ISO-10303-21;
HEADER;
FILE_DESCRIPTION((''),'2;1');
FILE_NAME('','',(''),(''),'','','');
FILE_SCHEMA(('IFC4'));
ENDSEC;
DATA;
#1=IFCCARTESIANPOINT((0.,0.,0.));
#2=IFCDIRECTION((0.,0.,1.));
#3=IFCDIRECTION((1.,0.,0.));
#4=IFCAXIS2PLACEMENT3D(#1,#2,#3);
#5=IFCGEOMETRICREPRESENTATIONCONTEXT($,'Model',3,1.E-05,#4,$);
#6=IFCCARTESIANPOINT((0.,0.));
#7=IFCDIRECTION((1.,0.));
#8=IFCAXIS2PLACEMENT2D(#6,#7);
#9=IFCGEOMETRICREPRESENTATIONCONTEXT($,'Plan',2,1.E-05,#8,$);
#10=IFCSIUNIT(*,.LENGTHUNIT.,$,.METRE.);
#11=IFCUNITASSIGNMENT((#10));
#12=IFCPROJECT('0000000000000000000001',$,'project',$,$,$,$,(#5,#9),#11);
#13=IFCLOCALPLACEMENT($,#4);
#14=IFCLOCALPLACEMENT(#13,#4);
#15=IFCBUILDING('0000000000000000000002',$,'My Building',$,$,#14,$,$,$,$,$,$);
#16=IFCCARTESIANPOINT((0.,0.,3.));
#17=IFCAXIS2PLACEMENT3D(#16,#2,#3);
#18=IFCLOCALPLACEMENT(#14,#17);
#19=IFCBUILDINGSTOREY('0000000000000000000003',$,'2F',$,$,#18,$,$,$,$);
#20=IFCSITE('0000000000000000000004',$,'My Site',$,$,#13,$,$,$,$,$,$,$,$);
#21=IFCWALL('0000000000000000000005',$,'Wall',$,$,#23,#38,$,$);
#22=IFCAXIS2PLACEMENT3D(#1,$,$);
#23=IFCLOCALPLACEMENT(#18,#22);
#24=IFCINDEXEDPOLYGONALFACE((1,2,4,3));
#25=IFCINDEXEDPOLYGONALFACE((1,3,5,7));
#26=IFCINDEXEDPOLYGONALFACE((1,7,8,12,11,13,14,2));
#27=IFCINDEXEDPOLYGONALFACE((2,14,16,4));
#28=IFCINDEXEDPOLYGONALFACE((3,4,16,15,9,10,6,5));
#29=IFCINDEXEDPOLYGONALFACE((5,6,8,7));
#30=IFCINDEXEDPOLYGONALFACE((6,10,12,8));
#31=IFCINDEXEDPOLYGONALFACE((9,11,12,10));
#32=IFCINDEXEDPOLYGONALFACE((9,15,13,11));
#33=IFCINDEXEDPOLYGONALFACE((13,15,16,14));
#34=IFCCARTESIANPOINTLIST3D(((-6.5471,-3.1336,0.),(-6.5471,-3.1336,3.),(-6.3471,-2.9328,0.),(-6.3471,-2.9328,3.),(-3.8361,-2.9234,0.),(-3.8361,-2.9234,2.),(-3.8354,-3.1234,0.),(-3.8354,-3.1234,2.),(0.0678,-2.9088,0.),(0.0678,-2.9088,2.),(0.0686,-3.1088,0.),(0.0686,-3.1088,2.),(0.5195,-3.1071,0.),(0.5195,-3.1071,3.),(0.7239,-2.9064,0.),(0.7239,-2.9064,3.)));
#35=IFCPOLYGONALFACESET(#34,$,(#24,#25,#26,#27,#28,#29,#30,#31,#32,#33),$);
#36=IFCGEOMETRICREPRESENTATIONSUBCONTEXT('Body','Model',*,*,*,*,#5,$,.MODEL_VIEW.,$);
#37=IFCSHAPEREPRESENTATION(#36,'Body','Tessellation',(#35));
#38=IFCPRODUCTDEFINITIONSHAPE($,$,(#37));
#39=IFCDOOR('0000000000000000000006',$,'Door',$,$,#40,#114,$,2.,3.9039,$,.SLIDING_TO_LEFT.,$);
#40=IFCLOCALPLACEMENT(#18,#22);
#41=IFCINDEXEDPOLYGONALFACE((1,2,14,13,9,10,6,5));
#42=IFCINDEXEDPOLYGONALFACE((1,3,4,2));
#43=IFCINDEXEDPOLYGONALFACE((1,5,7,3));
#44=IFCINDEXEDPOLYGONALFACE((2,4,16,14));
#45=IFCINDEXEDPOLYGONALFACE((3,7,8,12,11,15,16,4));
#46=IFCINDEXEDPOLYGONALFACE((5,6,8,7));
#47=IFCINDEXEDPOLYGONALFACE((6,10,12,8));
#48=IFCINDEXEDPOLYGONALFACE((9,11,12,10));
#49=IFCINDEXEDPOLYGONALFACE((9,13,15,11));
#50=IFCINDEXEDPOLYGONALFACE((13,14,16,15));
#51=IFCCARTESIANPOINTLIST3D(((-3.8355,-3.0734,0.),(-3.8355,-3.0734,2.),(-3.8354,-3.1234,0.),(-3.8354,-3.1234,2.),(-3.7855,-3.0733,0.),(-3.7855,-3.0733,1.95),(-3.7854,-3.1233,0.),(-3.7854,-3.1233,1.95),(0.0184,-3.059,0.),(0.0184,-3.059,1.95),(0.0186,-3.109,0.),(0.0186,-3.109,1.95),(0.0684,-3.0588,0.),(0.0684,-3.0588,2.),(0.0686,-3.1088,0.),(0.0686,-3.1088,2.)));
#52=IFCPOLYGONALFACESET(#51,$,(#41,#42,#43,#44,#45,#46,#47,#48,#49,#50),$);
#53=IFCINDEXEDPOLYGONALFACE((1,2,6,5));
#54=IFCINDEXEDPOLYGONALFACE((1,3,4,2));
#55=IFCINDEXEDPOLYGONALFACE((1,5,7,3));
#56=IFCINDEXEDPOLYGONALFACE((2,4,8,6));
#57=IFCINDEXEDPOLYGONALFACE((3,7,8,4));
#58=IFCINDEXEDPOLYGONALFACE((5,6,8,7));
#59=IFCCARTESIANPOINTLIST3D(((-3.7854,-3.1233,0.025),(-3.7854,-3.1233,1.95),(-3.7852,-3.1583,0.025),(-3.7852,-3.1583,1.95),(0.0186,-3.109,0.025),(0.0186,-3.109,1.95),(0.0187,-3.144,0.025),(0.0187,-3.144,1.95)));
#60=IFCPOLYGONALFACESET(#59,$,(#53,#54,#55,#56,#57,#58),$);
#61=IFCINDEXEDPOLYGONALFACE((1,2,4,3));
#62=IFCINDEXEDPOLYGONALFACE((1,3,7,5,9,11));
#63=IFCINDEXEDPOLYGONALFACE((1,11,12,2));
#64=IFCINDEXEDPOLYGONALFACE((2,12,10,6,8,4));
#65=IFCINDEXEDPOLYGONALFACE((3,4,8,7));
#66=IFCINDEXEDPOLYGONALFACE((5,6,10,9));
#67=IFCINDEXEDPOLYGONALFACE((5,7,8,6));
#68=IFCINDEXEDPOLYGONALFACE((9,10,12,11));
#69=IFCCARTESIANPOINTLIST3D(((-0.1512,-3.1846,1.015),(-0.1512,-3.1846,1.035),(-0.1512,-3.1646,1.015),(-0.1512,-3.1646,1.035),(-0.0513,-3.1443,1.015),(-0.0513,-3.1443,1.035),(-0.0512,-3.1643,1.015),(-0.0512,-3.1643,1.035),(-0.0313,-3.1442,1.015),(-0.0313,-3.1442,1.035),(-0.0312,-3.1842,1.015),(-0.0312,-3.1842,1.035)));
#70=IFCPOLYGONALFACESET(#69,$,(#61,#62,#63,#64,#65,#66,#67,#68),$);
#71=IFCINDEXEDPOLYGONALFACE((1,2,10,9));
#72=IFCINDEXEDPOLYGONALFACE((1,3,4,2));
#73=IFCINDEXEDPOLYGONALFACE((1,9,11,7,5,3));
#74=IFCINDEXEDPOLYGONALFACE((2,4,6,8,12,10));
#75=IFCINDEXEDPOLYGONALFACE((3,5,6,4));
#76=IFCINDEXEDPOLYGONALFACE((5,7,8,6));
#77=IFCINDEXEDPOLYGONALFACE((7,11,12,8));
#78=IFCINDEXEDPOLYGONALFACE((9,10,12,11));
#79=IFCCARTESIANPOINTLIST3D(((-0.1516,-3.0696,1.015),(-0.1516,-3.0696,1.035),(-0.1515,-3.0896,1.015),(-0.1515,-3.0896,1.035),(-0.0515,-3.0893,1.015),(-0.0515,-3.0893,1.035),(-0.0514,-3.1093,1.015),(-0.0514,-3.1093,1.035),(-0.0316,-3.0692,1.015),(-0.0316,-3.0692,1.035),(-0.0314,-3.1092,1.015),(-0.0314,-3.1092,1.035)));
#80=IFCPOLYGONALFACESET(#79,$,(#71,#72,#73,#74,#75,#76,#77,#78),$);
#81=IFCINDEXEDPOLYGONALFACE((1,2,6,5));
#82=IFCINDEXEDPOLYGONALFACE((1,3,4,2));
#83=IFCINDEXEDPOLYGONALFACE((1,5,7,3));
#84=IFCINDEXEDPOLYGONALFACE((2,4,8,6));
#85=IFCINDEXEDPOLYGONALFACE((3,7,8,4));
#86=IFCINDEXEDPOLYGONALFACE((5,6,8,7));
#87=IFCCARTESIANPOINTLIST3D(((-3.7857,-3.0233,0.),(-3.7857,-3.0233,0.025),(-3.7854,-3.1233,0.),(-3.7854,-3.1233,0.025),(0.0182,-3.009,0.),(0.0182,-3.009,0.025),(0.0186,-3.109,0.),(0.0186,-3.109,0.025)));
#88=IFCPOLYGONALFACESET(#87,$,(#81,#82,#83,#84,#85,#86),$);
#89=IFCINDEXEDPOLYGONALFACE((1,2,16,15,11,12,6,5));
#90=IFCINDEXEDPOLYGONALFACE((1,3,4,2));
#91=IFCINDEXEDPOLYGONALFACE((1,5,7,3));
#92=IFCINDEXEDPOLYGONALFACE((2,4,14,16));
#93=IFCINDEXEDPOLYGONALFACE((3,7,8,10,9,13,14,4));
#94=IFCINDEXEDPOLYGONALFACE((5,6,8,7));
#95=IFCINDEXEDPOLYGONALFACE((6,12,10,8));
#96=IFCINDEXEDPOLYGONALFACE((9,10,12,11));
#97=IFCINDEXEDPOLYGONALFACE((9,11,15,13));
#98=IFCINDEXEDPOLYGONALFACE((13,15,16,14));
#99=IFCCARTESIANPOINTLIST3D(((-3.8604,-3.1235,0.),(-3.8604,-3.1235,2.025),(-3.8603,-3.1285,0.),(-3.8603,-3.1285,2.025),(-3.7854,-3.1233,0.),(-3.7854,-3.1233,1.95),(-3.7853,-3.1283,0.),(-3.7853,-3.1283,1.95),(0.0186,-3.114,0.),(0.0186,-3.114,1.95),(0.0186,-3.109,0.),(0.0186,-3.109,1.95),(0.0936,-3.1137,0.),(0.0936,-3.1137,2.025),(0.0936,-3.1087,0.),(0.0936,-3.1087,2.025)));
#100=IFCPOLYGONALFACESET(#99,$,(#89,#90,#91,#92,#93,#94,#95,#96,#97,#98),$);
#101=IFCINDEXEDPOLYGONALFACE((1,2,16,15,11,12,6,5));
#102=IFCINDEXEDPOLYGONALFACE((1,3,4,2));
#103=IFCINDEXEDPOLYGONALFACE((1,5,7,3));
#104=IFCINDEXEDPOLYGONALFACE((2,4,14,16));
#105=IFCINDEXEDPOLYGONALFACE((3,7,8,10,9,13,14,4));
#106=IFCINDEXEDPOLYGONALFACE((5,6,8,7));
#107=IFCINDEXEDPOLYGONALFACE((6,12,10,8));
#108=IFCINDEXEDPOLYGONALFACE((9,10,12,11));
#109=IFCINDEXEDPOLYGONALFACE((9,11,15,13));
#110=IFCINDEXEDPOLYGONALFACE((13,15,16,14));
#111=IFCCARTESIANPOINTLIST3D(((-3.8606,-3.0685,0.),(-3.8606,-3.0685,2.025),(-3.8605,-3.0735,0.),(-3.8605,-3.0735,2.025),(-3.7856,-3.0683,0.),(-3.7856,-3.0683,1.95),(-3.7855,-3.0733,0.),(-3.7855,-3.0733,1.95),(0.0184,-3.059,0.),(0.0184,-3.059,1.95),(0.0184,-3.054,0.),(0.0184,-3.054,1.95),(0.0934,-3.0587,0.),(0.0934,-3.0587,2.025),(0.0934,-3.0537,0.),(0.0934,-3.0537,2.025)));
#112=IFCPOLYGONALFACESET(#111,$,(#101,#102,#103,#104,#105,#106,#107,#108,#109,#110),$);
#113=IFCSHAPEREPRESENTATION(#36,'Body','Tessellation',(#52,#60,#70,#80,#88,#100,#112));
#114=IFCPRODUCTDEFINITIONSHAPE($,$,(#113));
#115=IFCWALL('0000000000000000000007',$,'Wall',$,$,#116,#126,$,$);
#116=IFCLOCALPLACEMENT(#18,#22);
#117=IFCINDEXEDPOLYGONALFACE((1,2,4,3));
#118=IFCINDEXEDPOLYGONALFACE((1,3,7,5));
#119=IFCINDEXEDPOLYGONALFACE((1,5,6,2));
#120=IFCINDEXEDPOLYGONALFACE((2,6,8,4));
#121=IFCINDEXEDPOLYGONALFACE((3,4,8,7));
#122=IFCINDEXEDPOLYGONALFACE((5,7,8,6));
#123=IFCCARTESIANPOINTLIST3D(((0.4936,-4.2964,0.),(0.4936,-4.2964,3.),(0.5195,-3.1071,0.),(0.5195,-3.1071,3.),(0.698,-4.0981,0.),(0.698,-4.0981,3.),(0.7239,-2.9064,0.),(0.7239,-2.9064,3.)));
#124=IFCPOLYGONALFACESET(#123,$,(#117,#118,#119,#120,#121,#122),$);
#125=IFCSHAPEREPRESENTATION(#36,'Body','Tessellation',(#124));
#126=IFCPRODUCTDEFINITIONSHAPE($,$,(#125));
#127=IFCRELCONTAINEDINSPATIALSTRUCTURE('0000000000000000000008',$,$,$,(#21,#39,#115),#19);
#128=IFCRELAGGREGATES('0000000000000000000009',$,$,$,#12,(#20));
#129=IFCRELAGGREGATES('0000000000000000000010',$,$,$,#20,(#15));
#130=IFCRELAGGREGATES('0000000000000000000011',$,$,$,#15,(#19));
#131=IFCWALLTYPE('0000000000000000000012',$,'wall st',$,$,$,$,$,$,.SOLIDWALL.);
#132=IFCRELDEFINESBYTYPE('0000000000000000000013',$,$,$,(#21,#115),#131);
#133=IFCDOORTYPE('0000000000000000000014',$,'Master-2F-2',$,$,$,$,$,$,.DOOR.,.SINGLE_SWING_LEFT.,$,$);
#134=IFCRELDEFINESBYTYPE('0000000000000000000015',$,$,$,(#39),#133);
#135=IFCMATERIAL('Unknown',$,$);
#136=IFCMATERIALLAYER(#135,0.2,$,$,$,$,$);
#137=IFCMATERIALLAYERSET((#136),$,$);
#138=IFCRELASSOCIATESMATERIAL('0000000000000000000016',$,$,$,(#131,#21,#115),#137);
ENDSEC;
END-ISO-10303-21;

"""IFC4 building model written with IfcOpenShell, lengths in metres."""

from ifc_helpers import new_model, entity, si_unit, frame, origin_with_axes, origin_2d_with_axis, place, context, subcontext, project, spatial, line, indexed_curve, outline, extrude, shape, source, transform, mapped, material, layer, layer_set, layer_usage, type_object, type_shapes, element, fill, save


model = new_model("IFC4")

# Units and contexts
model_context = context("Model", 3, precision=1e-05, world=origin_with_axes())
plan_context = context("Plan", 2, precision=1e-05, world=origin_2d_with_axis())
body_context_1 = subcontext(model_context, "Body", "Model", "MODEL_VIEW")
body_context_2 = subcontext(plan_context, "Body", "Plan", "PLAN_VIEW")
ifc_project = project(units=[si_unit("LENGTHUNIT", "METRE")], contexts=[model_context, plan_context])

# Site, building, storey
site_placement = place(None, origin_with_axes())
site = spatial("IfcSite", under=ifc_project, at=site_placement, Name="My Site")
building_placement = place(site_placement, origin_with_axes())
building = spatial("IfcBuilding", under=site, at=building_placement, Name="My Building")
storey_placement = place(building_placement, frame((0.0, 0.0, 3.0), z_axis=(0.0, 0.0, 1.0), x_axis=(1.0, 0.0, 0.0)))
storey = spatial("IfcBuildingStorey", under=building, at=storey_placement, Name="2F")

# Shared definitions
ifc_material = material(Name="Unknown")

# Wall, opening, door
ifc_layer_1 = layer(ifc_material, 0.2)
ifc_layer_set_1 = layer_set([ifc_layer_1])
ifc_layer_usage_1 = layer_usage(ifc_layer_set_1, "AXIS2", "POSITIVE", 0.0)
wall_type_1 = type_object("IfcWallType", Name="wall st", PredefinedType="SOLIDWALL", material=ifc_layer_set_1)
wall_1_placement = place(storey_placement, frame((-6.5471, -3.1336, 0.0), z_axis=(0.0, 0.0, 1.0), x_axis=(0.999993, 0.003745, 0.0)))
wall_1 = element("IfcWall", 1, at=wall_1_placement, inside=storey, type_object=wall_type_1, material=ifc_layer_usage_1, Name="Wall", context=body_context_1, shape_type="SweptSolid", body=[
    extrude(outline(indexed_curve([(0.0, 0.0), (0.2008, 0.2), (7.2718, 0.2), (7.0666, 0.0)], segments=[line(1, 2, 3, 4, 1)])), origin_with_axes(), (0.0, 0.0, 1.0), 3.0),
])
shared_shape_1 = source(origin_with_axes(), body_context_1, "Body", "SweptSolid", [
    extrude(outline(indexed_curve([(0.0, 0.0), (3.9039, 0.0), (3.9039, 2.0), (0.0, 2.0)], segments=[line(1, 2, 3, 4, 1)])), frame((0.0, -0.6, 0.0), z_axis=(0.0, -1.0, 0.0), x_axis=(1.0, 0.0, 0.0)), (0.0, 0.0, -1.0), 1.2),
])
opening_1_placement = place(wall_1_placement, frame((2.7118, 0.0, 0.0), z_axis=(0.0, 0.0, 1.0), x_axis=(1.0, 0.0, 0.0)))
opening_1 = element("IfcOpeningElement", 2, at=opening_1_placement, cuts=wall_1, PredefinedType="OPENING", context=body_context_1, shape_type="MappedRepresentation", body=[
    mapped(shared_shape_1, transform((0.0, 0.0, 0.0), x_axis=(1.0, 0.0, 0.0), y_axis=(0.0, 1.0, 0.0), z_axis=(0.0, 0.0, 1.0), scale=1.0)),
])
door_type_1 = type_object("IfcDoorType", Name="Master-2F-2", OperationType="SINGLE_SWING_LEFT", PredefinedType="DOOR")
shared_shape_2 = source(origin_with_axes(), body_context_1, "Body", "SweptSolid", [
    extrude(outline(indexed_curve([(0.0, 0.0), (0.0, 2.0), (3.9039, 2.0), (3.9039, 0.0), (3.8539, 0.0), (3.8539, 1.95), (0.05, 1.95), (0.05, 0.0)], segments=[line(1, 2, 3, 4, 5, 6, 7, 8, 1)])), frame((0.0, 0.0, 0.0), z_axis=(0.0, -1.0, 0.0), x_axis=(1.0, 0.0, 0.0)), (0.0, 0.0, -1.0), 0.05),
    extrude(outline(indexed_curve([(0.0, 0.0), (3.8039, 0.0), (3.8039, 0.035), (0.0, 0.035)], segments=[line(1, 2, 3, 4, 1)])), frame((0.05, -0.035, 0.025), z_axis=(0.0, 0.0, 1.0), x_axis=(1.0, 0.0, 0.0)), (0.0, 0.0, 1.0), 1.925),
    extrude(outline(indexed_curve([(0.0, 0.0), (0.0, -0.04), (-0.12, -0.04), (-0.12, -0.02), (-0.02, -0.02), (-0.02, 0.0)], segments=[line(1, 2, 3, 4, 5, 6, 1)])), frame((3.8039, -0.035, 1.015), z_axis=(0.0, 0.0, 1.0), x_axis=(1.0, 0.0, 0.0)), (0.0, 0.0, 1.0), 0.02),
    extrude(outline(indexed_curve([(0.0, 0.0), (0.0, 0.04), (-0.12, 0.04), (-0.12, 0.02), (-0.02, 0.02), (-0.02, 0.0)], segments=[line(1, 2, 3, 4, 5, 6, 1)])), frame((3.8039, 0.0, 1.015), z_axis=(0.0, 0.0, 1.0), x_axis=(1.0, 0.0, 0.0)), (0.0, 0.0, 1.0), 0.02),
    extrude(outline(indexed_curve([(0.0, 0.0), (3.8039, 0.0), (3.8039, 0.1), (0.0, 0.1)], segments=[line(1, 2, 3, 4, 1)])), frame((0.05, 0.0, 0.0), z_axis=(0.0, 0.0, 1.0), x_axis=(1.0, 0.0, 0.0)), (0.0, 0.0, 1.0), 0.025),
    extrude(outline(indexed_curve([(0.0, 0.0), (0.0, 2.025), (3.9539, 2.025), (3.9539, 0.0), (3.8789, 0.0), (3.8789, 1.95), (0.075, 1.95), (0.075, 0.0)], segments=[line(1, 2, 3, 4, 5, 6, 7, 8, 1)])), frame((-0.025, -0.005, 0.0), z_axis=(0.0, -1.0, 0.0), x_axis=(1.0, 0.0, 0.0)), (0.0, 0.0, -1.0), 0.005),
    extrude(outline(indexed_curve([(0.0, 0.0), (0.0, 2.025), (3.9539, 2.025), (3.9539, 0.0), (3.8789, 0.0), (3.8789, 1.95), (0.075, 1.95), (0.075, 0.0)], segments=[line(1, 2, 3, 4, 5, 6, 7, 8, 1)])), frame((-0.025, 0.05, 0.0), z_axis=(0.0, -1.0, 0.0), x_axis=(1.0, 0.0, 0.0)), (0.0, 0.0, -1.0), 0.005),
])
shared_shape_3 = source(origin_with_axes(), body_context_2, "Body", "Curve2D", [
    entity("IfcIndexedPolyCurve", entity("IfcCartesianPointList2D", [[0.0, 0.0], [0.05, 0.0], [0.05, 0.05], [0.0, 0.05]]), [entity("IfcLineIndex", [1, 2, 3, 4, 1])]),
    entity("IfcIndexedPolyCurve", entity("IfcCartesianPointList2D", [[3.9039, 0.0], [3.8539, 0.0], [3.8539, 0.05], [3.9039, 0.05]]), [entity("IfcLineIndex", [1, 2, 3, 4, 1])]),
    entity("IfcIndexedPolyCurve", entity("IfcCartesianPointList2D", [[-1.852, -0.035], [1.952, -0.035], [1.952, 0.0], [-1.852, 0.0]]), [entity("IfcLineIndex", [1, 2, 3, 4, 1])]),
])
type_shapes(door_type_1, [shared_shape_2, shared_shape_3])
door_1_placement = place(opening_1_placement, frame((0.0, 0.0, 0.0), z_axis=(0.0, 0.0, 1.0), x_axis=(1.0, 0.0, 0.0)))
door_1 = element("IfcDoor", 3, at=door_1_placement, inside=storey, type_object=door_type_1, Name="Door", OperationType="SLIDING_TO_LEFT", OverallHeight=2.0, OverallWidth=3.9039, shapes=[
    shape(body_context_1, "Body", "MappedRepresentation", [mapped(shared_shape_2, transform((0.0, 0.0, 0.0), x_axis=(1.0, 0.0, 0.0), y_axis=(0.0, 1.0, 0.0), z_axis=(0.0, 0.0, 1.0), scale=1.0))]),
    shape(body_context_2, "Body", "MappedRepresentation", [mapped(shared_shape_3, transform((0.0, 0.0, 0.0), x_axis=(1.0, 0.0, 0.0), y_axis=(0.0, 1.0, 0.0), z_axis=(0.0, 0.0, 1.0), scale=1.0))]),
])
fill(opening_1, door_1)

# Wall
ifc_layer_usage_2 = layer_usage(ifc_layer_set_1, "AXIS2", "POSITIVE", 0.0)
wall_2_placement = place(storey_placement, frame((0.5195, -3.1071, 0.0), z_axis=(0.0, 0.0, 1.0), x_axis=(-0.021734, -0.999764, 0.0)))
element("IfcWall", 4, at=wall_2_placement, inside=storey, type_object=wall_type_1, material=ifc_layer_usage_2, Name="Wall", context=body_context_1, shape_type="SweptSolid", body=[
    extrude(outline(indexed_curve([(0.0, 0.0), (-0.2052, 0.2), (0.9869, 0.2), (1.1896, 0.0)], segments=[line(1, 2, 3, 4, 1)])), origin_with_axes(), (0.0, 0.0, 1.0), 3.0),
])

save(model, "model.ifc")
